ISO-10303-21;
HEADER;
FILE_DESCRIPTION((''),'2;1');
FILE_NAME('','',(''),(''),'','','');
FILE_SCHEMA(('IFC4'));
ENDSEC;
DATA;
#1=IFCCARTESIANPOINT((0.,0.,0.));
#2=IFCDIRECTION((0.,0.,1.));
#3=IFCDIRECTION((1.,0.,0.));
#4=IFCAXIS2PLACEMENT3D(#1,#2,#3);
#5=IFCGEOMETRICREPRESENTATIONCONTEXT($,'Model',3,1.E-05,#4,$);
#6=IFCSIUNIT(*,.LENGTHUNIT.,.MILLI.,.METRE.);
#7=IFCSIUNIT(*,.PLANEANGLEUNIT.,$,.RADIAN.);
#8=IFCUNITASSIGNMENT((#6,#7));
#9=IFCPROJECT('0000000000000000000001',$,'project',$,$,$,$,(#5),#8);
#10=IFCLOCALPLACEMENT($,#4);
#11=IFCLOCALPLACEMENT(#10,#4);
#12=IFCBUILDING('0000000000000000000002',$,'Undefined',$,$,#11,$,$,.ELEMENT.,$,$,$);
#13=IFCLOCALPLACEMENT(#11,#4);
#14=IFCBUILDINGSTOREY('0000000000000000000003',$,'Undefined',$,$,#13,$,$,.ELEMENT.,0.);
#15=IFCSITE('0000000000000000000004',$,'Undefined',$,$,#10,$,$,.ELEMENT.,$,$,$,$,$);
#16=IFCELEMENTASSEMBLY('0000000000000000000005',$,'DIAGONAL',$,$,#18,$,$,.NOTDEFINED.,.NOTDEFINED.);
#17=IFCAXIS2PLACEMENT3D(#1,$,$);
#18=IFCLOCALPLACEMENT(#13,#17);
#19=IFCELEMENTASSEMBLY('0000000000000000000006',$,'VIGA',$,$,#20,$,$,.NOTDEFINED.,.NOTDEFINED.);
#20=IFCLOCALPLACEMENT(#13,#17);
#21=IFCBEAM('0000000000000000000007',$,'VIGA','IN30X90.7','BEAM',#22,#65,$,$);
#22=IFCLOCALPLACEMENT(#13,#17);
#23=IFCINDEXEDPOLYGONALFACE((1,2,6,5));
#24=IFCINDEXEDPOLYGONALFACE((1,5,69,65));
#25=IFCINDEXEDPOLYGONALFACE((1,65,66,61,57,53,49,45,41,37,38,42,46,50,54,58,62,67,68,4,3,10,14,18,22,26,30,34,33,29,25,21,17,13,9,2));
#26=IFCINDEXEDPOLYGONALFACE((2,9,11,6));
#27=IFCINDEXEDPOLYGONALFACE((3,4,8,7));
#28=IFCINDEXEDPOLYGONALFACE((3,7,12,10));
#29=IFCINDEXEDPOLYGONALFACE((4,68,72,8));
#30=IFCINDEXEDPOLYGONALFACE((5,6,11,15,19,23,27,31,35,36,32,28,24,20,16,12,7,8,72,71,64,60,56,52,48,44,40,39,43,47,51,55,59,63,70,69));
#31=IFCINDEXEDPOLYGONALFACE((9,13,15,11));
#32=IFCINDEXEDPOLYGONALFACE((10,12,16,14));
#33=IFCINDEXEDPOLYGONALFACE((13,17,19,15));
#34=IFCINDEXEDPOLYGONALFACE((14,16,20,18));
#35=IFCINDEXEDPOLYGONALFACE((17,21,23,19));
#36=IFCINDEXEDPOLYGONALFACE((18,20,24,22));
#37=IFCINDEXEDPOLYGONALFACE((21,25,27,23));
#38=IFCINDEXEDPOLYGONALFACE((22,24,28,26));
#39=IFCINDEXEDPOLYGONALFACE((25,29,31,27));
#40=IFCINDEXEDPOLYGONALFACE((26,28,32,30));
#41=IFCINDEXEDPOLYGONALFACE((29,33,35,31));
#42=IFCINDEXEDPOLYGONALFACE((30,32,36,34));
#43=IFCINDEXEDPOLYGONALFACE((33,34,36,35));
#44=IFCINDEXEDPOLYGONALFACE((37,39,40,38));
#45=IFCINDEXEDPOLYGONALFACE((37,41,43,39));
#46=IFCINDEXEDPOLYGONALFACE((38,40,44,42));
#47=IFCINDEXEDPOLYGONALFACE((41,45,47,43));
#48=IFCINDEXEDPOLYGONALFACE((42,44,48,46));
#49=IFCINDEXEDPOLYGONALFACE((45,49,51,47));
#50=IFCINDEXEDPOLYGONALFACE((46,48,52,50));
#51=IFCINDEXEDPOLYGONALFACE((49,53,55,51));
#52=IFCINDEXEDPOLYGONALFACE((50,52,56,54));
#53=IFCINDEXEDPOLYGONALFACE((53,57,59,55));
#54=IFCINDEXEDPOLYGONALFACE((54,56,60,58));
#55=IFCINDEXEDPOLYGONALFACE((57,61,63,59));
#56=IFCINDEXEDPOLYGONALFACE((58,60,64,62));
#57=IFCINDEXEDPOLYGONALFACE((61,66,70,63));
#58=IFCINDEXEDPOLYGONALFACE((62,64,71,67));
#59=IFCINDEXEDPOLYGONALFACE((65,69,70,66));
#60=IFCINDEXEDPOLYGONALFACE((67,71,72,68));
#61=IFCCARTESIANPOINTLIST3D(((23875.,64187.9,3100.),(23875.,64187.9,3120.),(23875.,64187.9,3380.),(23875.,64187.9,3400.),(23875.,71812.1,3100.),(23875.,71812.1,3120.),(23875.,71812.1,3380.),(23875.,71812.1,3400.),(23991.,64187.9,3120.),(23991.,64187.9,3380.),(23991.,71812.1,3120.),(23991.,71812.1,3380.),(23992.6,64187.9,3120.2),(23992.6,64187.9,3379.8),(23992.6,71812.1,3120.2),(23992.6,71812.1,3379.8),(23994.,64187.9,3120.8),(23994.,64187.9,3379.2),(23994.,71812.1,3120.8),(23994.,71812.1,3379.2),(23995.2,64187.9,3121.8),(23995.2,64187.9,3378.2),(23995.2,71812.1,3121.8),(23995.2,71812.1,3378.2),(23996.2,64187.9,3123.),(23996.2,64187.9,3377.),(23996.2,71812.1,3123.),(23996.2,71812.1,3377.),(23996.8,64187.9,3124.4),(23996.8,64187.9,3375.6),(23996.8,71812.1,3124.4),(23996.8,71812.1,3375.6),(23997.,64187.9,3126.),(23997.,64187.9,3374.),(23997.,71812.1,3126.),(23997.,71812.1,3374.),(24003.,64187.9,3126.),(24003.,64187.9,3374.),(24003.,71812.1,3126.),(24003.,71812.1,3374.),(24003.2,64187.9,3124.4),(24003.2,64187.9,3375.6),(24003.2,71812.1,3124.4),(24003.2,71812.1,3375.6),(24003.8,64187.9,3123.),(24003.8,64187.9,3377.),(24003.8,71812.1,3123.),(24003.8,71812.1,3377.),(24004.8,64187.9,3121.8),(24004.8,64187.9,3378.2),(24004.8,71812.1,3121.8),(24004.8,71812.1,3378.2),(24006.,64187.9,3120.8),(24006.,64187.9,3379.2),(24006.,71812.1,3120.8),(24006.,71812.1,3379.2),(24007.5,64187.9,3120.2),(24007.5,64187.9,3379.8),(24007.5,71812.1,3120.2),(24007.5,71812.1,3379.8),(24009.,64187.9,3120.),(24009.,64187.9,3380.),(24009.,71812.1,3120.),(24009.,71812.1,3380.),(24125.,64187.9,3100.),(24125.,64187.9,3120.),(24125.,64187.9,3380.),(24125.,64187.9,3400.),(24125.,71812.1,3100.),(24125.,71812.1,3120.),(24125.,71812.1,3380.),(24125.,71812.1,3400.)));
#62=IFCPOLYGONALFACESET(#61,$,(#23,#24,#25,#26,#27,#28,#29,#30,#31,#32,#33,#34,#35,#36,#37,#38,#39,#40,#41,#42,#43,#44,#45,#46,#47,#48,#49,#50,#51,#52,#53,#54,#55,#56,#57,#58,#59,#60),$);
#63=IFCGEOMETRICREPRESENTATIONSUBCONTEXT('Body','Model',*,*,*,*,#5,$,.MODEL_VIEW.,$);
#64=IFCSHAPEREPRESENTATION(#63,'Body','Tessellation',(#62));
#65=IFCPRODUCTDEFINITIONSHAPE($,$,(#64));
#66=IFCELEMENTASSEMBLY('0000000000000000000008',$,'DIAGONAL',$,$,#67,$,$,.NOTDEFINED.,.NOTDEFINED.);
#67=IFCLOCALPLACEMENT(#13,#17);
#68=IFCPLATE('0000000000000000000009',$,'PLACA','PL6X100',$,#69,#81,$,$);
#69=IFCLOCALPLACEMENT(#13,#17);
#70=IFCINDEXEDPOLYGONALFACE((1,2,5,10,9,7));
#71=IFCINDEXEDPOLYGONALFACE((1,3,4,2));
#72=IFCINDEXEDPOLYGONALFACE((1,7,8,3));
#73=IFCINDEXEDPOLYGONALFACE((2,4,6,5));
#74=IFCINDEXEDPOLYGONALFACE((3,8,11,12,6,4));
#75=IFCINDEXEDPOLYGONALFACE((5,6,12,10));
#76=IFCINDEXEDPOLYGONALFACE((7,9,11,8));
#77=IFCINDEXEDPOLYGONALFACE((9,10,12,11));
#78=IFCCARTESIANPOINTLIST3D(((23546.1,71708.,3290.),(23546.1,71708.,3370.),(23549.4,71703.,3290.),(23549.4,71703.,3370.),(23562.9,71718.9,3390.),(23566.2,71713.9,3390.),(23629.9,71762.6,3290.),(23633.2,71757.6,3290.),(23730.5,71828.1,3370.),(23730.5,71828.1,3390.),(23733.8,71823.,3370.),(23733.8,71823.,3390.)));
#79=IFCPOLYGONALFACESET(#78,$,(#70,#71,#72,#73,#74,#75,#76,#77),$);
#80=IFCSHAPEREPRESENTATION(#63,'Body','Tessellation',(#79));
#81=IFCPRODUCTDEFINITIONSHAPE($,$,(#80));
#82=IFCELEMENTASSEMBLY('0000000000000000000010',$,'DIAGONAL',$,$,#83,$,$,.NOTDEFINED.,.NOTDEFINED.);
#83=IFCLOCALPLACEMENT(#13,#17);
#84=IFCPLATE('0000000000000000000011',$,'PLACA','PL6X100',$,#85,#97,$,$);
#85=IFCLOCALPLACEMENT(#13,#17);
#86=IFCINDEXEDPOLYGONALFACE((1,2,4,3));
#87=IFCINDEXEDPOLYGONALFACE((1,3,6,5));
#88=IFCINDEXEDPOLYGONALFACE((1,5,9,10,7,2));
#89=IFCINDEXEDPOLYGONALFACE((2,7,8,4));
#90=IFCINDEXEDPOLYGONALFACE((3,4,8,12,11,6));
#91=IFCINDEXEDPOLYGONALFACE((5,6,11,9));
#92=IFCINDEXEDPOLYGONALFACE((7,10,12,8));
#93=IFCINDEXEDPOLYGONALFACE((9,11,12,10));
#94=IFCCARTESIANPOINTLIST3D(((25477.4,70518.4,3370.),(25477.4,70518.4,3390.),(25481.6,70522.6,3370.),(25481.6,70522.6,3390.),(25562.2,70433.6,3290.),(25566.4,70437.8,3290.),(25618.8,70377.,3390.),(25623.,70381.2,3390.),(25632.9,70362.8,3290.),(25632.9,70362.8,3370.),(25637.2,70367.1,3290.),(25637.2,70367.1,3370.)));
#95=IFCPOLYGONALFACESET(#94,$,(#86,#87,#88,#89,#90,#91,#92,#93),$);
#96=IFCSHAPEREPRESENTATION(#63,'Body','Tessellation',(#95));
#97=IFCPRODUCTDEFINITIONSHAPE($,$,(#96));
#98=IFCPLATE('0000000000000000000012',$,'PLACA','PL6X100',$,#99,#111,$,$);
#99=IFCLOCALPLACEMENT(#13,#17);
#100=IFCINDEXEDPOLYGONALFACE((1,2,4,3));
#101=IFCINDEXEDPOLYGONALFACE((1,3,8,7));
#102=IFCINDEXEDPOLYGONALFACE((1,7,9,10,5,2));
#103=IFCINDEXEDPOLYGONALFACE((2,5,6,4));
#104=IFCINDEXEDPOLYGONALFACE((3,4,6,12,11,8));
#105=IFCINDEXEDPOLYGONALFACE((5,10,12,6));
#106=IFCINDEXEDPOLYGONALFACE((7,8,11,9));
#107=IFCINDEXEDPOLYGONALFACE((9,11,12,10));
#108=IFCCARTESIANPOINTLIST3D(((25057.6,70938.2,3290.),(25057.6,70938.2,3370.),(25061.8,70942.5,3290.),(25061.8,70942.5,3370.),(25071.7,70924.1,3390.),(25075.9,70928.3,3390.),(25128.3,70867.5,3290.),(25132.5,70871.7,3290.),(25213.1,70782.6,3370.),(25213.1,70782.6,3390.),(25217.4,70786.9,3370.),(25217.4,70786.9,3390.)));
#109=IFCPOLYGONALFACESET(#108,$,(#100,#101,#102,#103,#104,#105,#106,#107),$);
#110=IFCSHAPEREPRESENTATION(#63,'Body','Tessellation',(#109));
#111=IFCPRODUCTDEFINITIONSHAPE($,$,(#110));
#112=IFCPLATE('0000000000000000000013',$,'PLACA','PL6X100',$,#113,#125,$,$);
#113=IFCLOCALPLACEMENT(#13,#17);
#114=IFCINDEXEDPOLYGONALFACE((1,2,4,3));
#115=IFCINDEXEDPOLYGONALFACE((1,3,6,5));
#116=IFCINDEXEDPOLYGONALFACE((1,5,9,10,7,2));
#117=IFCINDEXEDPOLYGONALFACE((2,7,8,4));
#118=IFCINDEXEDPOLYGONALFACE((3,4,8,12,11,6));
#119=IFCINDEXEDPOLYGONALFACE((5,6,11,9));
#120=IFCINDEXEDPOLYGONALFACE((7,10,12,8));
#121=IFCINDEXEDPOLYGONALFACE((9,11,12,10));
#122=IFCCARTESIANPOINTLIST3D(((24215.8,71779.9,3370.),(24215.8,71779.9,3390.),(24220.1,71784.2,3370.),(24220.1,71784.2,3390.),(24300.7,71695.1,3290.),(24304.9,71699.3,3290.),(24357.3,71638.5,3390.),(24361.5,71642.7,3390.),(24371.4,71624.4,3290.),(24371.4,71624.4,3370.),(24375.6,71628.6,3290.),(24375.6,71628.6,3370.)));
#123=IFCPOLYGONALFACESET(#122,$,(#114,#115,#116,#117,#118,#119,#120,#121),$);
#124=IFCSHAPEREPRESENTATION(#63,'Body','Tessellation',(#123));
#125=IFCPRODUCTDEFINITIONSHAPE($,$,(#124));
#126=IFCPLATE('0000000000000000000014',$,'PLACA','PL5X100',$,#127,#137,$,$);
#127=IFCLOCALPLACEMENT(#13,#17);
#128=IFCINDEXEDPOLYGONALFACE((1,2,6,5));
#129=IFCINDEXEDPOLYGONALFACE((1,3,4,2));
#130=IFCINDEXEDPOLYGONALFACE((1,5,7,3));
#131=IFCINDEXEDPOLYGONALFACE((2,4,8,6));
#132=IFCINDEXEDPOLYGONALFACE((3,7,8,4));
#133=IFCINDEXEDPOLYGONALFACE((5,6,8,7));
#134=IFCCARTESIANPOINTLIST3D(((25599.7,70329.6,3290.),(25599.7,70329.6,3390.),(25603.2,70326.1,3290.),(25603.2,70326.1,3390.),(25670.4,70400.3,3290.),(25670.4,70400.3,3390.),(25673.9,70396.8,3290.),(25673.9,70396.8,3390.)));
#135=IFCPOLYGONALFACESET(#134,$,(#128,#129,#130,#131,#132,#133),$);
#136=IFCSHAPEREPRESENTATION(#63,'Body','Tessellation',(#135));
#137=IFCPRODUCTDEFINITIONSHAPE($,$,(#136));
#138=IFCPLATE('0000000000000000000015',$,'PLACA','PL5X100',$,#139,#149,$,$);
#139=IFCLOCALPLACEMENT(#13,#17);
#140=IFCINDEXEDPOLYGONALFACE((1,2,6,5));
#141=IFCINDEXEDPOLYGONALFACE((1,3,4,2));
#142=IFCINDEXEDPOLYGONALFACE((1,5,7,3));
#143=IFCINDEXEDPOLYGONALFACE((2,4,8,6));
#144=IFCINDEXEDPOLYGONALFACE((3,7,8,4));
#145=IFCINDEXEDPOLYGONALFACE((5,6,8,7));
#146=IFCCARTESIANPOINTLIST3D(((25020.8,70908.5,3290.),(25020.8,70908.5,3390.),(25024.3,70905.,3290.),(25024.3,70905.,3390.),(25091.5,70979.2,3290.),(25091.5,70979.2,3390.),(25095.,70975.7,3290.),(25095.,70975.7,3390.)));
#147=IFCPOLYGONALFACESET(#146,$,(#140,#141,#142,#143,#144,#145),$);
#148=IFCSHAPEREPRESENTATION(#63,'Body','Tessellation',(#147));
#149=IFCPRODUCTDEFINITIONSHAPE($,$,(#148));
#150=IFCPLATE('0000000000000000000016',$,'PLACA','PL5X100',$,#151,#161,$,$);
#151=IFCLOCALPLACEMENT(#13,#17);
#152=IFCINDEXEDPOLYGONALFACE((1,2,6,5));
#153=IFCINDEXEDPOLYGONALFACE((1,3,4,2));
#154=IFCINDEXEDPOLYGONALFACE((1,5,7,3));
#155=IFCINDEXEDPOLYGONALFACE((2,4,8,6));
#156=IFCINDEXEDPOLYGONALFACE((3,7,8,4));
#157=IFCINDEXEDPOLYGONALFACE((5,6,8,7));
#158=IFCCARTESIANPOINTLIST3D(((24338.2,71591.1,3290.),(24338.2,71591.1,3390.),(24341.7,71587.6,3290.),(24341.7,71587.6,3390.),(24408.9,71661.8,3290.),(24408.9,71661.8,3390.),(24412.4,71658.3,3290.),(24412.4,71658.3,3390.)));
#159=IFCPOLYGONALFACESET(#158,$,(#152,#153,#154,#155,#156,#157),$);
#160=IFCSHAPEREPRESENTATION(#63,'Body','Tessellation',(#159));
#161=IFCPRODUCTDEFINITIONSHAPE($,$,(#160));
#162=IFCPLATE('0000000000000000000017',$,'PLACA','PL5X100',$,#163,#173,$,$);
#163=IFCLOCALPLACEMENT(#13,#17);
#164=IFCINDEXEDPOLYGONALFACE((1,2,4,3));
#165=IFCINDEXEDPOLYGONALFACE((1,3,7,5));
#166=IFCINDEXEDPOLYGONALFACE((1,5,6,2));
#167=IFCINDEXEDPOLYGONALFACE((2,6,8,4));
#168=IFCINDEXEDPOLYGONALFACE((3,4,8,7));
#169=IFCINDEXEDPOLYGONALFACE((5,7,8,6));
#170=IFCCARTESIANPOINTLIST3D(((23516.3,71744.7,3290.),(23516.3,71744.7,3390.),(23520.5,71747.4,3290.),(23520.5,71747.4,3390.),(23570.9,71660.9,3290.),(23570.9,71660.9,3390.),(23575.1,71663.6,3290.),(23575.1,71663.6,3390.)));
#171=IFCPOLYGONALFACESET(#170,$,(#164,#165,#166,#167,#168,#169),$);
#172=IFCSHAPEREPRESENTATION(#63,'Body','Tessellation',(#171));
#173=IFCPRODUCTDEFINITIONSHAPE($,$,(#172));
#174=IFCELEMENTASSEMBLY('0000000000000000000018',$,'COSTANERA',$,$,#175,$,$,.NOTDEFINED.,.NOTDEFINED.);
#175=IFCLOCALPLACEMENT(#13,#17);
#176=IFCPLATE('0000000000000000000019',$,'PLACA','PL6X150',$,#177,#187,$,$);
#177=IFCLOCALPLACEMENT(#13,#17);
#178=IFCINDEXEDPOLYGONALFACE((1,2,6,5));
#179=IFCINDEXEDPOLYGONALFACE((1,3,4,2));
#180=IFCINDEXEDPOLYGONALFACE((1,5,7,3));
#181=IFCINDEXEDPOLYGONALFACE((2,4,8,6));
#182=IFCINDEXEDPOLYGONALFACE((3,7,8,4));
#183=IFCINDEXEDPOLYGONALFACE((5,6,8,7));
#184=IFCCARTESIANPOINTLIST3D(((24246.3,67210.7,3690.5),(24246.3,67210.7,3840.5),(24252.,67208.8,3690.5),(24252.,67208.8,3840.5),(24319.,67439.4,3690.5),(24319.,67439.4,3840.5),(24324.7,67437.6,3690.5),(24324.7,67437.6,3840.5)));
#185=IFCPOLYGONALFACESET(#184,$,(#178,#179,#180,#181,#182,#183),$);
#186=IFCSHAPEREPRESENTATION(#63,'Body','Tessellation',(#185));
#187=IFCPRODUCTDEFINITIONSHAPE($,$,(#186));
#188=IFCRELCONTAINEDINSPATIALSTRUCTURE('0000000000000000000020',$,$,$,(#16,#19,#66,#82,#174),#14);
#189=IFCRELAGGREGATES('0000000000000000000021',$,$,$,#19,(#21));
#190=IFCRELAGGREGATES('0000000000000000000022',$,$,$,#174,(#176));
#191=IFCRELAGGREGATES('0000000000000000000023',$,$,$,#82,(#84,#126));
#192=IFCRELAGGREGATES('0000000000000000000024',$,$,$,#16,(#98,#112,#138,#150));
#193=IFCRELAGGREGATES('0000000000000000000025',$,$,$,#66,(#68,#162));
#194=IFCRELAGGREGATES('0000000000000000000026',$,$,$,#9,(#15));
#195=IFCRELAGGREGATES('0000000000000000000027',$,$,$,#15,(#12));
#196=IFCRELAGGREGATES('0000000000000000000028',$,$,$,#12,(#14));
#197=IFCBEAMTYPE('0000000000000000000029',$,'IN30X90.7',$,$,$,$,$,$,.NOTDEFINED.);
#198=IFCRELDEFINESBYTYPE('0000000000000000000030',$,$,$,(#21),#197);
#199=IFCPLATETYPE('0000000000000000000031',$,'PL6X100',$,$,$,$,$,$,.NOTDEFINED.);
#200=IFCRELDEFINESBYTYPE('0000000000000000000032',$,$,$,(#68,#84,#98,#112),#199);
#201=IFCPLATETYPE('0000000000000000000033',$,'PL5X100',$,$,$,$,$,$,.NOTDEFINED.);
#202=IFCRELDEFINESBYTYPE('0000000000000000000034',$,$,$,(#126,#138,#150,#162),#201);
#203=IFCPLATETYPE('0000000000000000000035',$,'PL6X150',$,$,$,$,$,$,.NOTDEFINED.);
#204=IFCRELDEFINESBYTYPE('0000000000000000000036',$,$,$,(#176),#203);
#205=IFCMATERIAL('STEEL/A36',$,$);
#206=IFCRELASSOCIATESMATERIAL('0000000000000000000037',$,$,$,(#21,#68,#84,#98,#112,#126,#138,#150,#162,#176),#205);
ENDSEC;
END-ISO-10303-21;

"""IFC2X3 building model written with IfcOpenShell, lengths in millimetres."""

from ifc_helpers import new_model, si_unit, frame, origin_with_axes, origin_2d_with_axis, place, context, subcontext, project, spatial, polyline, i_section, outline, extrude, material, type_object, element, aggregate, save


model = new_model("IFC2X3")

# Units and contexts
model_context = context("Model", 3, precision=1e-05, world=origin_with_axes())
body_context = subcontext(model_context, "Body", "Model", "MODEL_VIEW")
ifc_project = project(units=[si_unit("LENGTHUNIT", "METRE", prefix="MILLI"), si_unit("PLANEANGLEUNIT", "RADIAN")], contexts=[model_context])

# Site, building, storey
site_placement = place(None, origin_with_axes())
site = spatial("IfcSite", under=ifc_project, at=site_placement, Name="Undefined", CompositionType="ELEMENT")
building_placement = place(site_placement, origin_with_axes())
building = spatial("IfcBuilding", under=site, at=building_placement, Name="Undefined", CompositionType="ELEMENT")
storey_placement = place(building_placement, origin_with_axes())
storey = spatial("IfcBuildingStorey", under=building, at=storey_placement, Name="Undefined", CompositionType="ELEMENT", Elevation=0.0)

# Element assemblies, beam
ifc_material_1 = material(Name="STEEL/A36")
assembly_1_placement = place(storey_placement, origin_with_axes())
assembly_1 = element("IfcElementAssembly", 1, at=assembly_1_placement, inside=storey, Name="DIAGONAL", AssemblyPlace="NOTDEFINED", PredefinedType="NOTDEFINED")
assembly_2_placement = place(storey_placement, origin_with_axes())
assembly_2 = element("IfcElementAssembly", 2, at=assembly_2_placement, inside=storey, Name="VIGA", AssemblyPlace="NOTDEFINED", PredefinedType="NOTDEFINED")
beam_type_1 = type_object("IfcBeamType", Name="IN30X90.7", PredefinedType="NOTDEFINED")
beam_1_placement = place(assembly_2_placement, frame((24000.0, 71812.1, 3250.0), z_axis=(0.0, 0.0, 1.0), x_axis=(0.0, -1.0, 0.0)))
beam_1 = element("IfcBeam", 3, at=beam_1_placement, type_object=beam_type_1, material=ifc_material_1, Name="VIGA", Description="IN30X90.7", ObjectType="BEAM", context=body_context, shape_type="SweptSolid", body=[
    extrude(i_section(OverallWidth=250.0, OverallDepth=300.0, WebThickness=6.0, FlangeThickness=20.0, FilletRadius=6.0, at=origin_2d_with_axis()), frame((7624.2, 0.0, 0.0), z_axis=(-1.0, 0.0, 0.0), x_axis=(0.0, -1.0, 0.0)), (0.0, 0.0, 1.0), 7624.2),
])
aggregate(assembly_2, [beam_1])

# Element assemblies, plates
assembly_3_placement = place(storey_placement, origin_with_axes())
assembly_3 = element("IfcElementAssembly", 4, at=assembly_3_placement, inside=storey, Name="DIAGONAL", AssemblyPlace="NOTDEFINED", PredefinedType="NOTDEFINED")
plate_type_1 = type_object("IfcPlateType", Name="PL6X100", PredefinedType="NOTDEFINED")
plate_1_placement = place(assembly_3_placement, frame((23732.1, 71825.5, 3290.0), z_axis=(-0.545706, 0.837977, 0.0), x_axis=(-0.837977, -0.545706, 0.0)))
plate_1 = element("IfcPlate", 5, at=plate_1_placement, type_object=plate_type_1, material=ifc_material_1, Name="PLACA", Description="PL6X100", context=body_context, shape_type="SweptSolid", body=[
    extrude(outline(polyline([(0.0, 80.0), (120.0, 0.0), (220.0, 0.0), (220.0, 80.0), (200.0, 100.0), (0.0, 100.0), (0.0, 80.0)])), frame((0.0, 0.0, -3.0), z_axis=(0.0, 0.0, 1.0), x_axis=(1.0, 0.0, 0.0)), (0.0, 0.0, 1.0), 6.0),
])
assembly_4_placement = place(storey_placement, origin_with_axes())
assembly_4 = element("IfcElementAssembly", 6, at=assembly_4_placement, inside=storey, Name="DIAGONAL", AssemblyPlace="NOTDEFINED", PredefinedType="NOTDEFINED")
plate_2_placement = place(assembly_4_placement, frame((25479.5, 70520.5, 3290.0), z_axis=(-0.707107, -0.707107, 0.0), x_axis=(0.707107, -0.707107, 0.0)))
plate_2 = element("IfcPlate", 7, at=plate_2_placement, type_object=plate_type_1, material=ifc_material_1, Name="PLACA", Description="PL6X100", context=body_context, shape_type="SweptSolid", body=[
    extrude(outline(polyline([(0.0, 80.0), (120.0, 0.0), (220.0, 0.0), (220.0, 80.0), (200.0, 100.0), (0.0, 100.0), (0.0, 80.0)])), frame((0.0, 0.0, -3.0), z_axis=(0.0, 0.0, 1.0), x_axis=(1.0, 0.0, 0.0)), (0.0, 0.0, 1.0), 6.0),
])

# Plates
plate_3_placement = place(assembly_1_placement, frame((25215.2, 70784.8, 3290.0), z_axis=(0.707107, 0.707107, 0.0), x_axis=(-0.707107, 0.707107, 0.0)))
plate_3 = element("IfcPlate", 8, at=plate_3_placement, type_object=plate_type_1, material=ifc_material_1, Name="PLACA", Description="PL6X100", context=body_context, shape_type="SweptSolid", body=[
    extrude(outline(polyline([(0.0, 80.0), (120.0, 0.0), (220.0, 0.0), (220.0, 80.0), (200.0, 100.0), (0.0, 100.0), (0.0, 80.0)])), frame((0.0, 0.0, -3.0), z_axis=(0.0, 0.0, 1.0), x_axis=(1.0, 0.0, 0.0)), (0.0, 0.0, 1.0), 6.0),
])
plate_4_placement = place(assembly_1_placement, frame((24218.0, 71782.0, 3290.0), z_axis=(-0.707107, -0.707107, 0.0), x_axis=(0.707107, -0.707107, 0.0)))
plate_4 = element("IfcPlate", 9, at=plate_4_placement, type_object=plate_type_1, material=ifc_material_1, Name="PLACA", Description="PL6X100", context=body_context, shape_type="SweptSolid", body=[
    extrude(outline(polyline([(0.0, 80.0), (120.0, 0.0), (220.0, 0.0), (220.0, 80.0), (200.0, 100.0), (0.0, 100.0), (0.0, 80.0)])), frame((0.0, 0.0, -3.0), z_axis=(0.0, 0.0, 1.0), x_axis=(1.0, 0.0, 0.0)), (0.0, 0.0, 1.0), 6.0),
])
plate_type_2 = type_object("IfcPlateType", Name="PL5X100", PredefinedType="NOTDEFINED")
plate_5_placement = place(assembly_4_placement, frame((25636.8, 70363.2, 3390.0), z_axis=(0.707107, -0.707107, 0.0), x_axis=(0.0, 0.0, -1.0)))
plate_5 = element("IfcPlate", 10, at=plate_5_placement, type_object=plate_type_2, material=ifc_material_1, Name="PLACA", Description="PL5X100", context=body_context, shape_type="SweptSolid", body=[
    extrude(outline(polyline([(0.0, -50.0), (0.0, 50.0), (100.0, 50.0), (100.0, -50.0), (0.0, -50.0)])), frame((0.0, 0.0, -2.5), z_axis=(0.0, 0.0, 1.0), x_axis=(1.0, 0.0, 0.0)), (0.0, 0.0, 1.0), 5.0),
])
plate_6_placement = place(assembly_1_placement, frame((25057.9, 70942.1, 3390.0), z_axis=(-0.707107, 0.707107, 0.0), x_axis=(0.0, 0.0, -1.0)))
plate_6 = element("IfcPlate", 11, at=plate_6_placement, type_object=plate_type_2, material=ifc_material_1, Name="PLACA", Description="PL5X100", context=body_context, shape_type="SweptSolid", body=[
    extrude(outline(polyline([(0.0, -50.0), (0.0, 50.0), (100.0, 50.0), (100.0, -50.0), (0.0, -50.0)])), frame((0.0, 0.0, -2.5), z_axis=(0.0, 0.0, 1.0), x_axis=(1.0, 0.0, 0.0)), (0.0, 0.0, 1.0), 5.0),
])
plate_7_placement = place(assembly_1_placement, frame((24339.9, 71589.4, 3390.0), z_axis=(0.707107, -0.707107, 0.0), x_axis=(0.0, 0.0, -1.0)))
plate_7 = element("IfcPlate", 12, at=plate_7_placement, type_object=plate_type_2, material=ifc_material_1, Name="PLACA", Description="PL5X100", context=body_context, shape_type="SweptSolid", body=[
    extrude(outline(polyline([(0.0, 0.0), (100.0, 0.0), (100.0, 100.0), (0.0, 100.0), (0.0, 0.0)])), frame((0.0, 0.0, -2.5), z_axis=(0.0, 0.0, 1.0), x_axis=(1.0, 0.0, 0.0)), (0.0, 0.0, 1.0), 5.0),
])
plate_8_placement = place(assembly_3_placement, frame((23518.4, 71746.0, 3390.0), z_axis=(-0.837977, -0.545706, 0.0), x_axis=(0.0, 0.0, -1.0)))
plate_8 = element("IfcPlate", 13, at=plate_8_placement, type_object=plate_type_2, material=ifc_material_1, Name="PLACA", Description="PL5X100", context=body_context, shape_type="SweptSolid", body=[
    extrude(outline(polyline([(0.0, 0.0), (100.0, 0.0), (100.0, 100.0), (0.0, 100.0), (0.0, 0.0)])), frame((0.0, 0.0, -2.5), z_axis=(0.0, 0.0, 1.0), x_axis=(1.0, 0.0, 0.0)), (0.0, 0.0, 1.0), 5.0),
])

# Element assembly, plate
assembly_5_placement = place(storey_placement, origin_with_axes())
assembly_5 = element("IfcElementAssembly", 14, at=assembly_5_placement, inside=storey, Name="COSTANERA", AssemblyPlace="NOTDEFINED", PredefinedType="NOTDEFINED")
plate_type_3 = type_object("IfcPlateType", Name="PL6X150", PredefinedType="NOTDEFINED")
plate_9_placement = place(assembly_5_placement, frame((24249.1, 67209.8, 3765.5), z_axis=(0.952956, -0.30311, 0.0), x_axis=(0.30311, 0.952956, 0.0)))
plate_9 = element("IfcPlate", 15, at=plate_9_placement, type_object=plate_type_3, material=ifc_material_1, Name="PLACA", Description="PL6X150", context=body_context, shape_type="SweptSolid", body=[
    extrude(outline(polyline([(0.0, -75.0), (0.0, 75.0), (240.0, 75.0), (240.0, -75.0), (0.0, -75.0)])), frame((0.0, 0.0, -3.0), z_axis=(0.0, 0.0, 1.0), x_axis=(1.0, 0.0, 0.0)), (0.0, 0.0, 1.0), 6.0),
])

aggregate(assembly_5, [plate_9])
aggregate(assembly_4, [plate_2, plate_5])
aggregate(assembly_1, [plate_3, plate_4, plate_6, plate_7])
aggregate(assembly_3, [plate_1, plate_8])

save(model, "model.ifc")
